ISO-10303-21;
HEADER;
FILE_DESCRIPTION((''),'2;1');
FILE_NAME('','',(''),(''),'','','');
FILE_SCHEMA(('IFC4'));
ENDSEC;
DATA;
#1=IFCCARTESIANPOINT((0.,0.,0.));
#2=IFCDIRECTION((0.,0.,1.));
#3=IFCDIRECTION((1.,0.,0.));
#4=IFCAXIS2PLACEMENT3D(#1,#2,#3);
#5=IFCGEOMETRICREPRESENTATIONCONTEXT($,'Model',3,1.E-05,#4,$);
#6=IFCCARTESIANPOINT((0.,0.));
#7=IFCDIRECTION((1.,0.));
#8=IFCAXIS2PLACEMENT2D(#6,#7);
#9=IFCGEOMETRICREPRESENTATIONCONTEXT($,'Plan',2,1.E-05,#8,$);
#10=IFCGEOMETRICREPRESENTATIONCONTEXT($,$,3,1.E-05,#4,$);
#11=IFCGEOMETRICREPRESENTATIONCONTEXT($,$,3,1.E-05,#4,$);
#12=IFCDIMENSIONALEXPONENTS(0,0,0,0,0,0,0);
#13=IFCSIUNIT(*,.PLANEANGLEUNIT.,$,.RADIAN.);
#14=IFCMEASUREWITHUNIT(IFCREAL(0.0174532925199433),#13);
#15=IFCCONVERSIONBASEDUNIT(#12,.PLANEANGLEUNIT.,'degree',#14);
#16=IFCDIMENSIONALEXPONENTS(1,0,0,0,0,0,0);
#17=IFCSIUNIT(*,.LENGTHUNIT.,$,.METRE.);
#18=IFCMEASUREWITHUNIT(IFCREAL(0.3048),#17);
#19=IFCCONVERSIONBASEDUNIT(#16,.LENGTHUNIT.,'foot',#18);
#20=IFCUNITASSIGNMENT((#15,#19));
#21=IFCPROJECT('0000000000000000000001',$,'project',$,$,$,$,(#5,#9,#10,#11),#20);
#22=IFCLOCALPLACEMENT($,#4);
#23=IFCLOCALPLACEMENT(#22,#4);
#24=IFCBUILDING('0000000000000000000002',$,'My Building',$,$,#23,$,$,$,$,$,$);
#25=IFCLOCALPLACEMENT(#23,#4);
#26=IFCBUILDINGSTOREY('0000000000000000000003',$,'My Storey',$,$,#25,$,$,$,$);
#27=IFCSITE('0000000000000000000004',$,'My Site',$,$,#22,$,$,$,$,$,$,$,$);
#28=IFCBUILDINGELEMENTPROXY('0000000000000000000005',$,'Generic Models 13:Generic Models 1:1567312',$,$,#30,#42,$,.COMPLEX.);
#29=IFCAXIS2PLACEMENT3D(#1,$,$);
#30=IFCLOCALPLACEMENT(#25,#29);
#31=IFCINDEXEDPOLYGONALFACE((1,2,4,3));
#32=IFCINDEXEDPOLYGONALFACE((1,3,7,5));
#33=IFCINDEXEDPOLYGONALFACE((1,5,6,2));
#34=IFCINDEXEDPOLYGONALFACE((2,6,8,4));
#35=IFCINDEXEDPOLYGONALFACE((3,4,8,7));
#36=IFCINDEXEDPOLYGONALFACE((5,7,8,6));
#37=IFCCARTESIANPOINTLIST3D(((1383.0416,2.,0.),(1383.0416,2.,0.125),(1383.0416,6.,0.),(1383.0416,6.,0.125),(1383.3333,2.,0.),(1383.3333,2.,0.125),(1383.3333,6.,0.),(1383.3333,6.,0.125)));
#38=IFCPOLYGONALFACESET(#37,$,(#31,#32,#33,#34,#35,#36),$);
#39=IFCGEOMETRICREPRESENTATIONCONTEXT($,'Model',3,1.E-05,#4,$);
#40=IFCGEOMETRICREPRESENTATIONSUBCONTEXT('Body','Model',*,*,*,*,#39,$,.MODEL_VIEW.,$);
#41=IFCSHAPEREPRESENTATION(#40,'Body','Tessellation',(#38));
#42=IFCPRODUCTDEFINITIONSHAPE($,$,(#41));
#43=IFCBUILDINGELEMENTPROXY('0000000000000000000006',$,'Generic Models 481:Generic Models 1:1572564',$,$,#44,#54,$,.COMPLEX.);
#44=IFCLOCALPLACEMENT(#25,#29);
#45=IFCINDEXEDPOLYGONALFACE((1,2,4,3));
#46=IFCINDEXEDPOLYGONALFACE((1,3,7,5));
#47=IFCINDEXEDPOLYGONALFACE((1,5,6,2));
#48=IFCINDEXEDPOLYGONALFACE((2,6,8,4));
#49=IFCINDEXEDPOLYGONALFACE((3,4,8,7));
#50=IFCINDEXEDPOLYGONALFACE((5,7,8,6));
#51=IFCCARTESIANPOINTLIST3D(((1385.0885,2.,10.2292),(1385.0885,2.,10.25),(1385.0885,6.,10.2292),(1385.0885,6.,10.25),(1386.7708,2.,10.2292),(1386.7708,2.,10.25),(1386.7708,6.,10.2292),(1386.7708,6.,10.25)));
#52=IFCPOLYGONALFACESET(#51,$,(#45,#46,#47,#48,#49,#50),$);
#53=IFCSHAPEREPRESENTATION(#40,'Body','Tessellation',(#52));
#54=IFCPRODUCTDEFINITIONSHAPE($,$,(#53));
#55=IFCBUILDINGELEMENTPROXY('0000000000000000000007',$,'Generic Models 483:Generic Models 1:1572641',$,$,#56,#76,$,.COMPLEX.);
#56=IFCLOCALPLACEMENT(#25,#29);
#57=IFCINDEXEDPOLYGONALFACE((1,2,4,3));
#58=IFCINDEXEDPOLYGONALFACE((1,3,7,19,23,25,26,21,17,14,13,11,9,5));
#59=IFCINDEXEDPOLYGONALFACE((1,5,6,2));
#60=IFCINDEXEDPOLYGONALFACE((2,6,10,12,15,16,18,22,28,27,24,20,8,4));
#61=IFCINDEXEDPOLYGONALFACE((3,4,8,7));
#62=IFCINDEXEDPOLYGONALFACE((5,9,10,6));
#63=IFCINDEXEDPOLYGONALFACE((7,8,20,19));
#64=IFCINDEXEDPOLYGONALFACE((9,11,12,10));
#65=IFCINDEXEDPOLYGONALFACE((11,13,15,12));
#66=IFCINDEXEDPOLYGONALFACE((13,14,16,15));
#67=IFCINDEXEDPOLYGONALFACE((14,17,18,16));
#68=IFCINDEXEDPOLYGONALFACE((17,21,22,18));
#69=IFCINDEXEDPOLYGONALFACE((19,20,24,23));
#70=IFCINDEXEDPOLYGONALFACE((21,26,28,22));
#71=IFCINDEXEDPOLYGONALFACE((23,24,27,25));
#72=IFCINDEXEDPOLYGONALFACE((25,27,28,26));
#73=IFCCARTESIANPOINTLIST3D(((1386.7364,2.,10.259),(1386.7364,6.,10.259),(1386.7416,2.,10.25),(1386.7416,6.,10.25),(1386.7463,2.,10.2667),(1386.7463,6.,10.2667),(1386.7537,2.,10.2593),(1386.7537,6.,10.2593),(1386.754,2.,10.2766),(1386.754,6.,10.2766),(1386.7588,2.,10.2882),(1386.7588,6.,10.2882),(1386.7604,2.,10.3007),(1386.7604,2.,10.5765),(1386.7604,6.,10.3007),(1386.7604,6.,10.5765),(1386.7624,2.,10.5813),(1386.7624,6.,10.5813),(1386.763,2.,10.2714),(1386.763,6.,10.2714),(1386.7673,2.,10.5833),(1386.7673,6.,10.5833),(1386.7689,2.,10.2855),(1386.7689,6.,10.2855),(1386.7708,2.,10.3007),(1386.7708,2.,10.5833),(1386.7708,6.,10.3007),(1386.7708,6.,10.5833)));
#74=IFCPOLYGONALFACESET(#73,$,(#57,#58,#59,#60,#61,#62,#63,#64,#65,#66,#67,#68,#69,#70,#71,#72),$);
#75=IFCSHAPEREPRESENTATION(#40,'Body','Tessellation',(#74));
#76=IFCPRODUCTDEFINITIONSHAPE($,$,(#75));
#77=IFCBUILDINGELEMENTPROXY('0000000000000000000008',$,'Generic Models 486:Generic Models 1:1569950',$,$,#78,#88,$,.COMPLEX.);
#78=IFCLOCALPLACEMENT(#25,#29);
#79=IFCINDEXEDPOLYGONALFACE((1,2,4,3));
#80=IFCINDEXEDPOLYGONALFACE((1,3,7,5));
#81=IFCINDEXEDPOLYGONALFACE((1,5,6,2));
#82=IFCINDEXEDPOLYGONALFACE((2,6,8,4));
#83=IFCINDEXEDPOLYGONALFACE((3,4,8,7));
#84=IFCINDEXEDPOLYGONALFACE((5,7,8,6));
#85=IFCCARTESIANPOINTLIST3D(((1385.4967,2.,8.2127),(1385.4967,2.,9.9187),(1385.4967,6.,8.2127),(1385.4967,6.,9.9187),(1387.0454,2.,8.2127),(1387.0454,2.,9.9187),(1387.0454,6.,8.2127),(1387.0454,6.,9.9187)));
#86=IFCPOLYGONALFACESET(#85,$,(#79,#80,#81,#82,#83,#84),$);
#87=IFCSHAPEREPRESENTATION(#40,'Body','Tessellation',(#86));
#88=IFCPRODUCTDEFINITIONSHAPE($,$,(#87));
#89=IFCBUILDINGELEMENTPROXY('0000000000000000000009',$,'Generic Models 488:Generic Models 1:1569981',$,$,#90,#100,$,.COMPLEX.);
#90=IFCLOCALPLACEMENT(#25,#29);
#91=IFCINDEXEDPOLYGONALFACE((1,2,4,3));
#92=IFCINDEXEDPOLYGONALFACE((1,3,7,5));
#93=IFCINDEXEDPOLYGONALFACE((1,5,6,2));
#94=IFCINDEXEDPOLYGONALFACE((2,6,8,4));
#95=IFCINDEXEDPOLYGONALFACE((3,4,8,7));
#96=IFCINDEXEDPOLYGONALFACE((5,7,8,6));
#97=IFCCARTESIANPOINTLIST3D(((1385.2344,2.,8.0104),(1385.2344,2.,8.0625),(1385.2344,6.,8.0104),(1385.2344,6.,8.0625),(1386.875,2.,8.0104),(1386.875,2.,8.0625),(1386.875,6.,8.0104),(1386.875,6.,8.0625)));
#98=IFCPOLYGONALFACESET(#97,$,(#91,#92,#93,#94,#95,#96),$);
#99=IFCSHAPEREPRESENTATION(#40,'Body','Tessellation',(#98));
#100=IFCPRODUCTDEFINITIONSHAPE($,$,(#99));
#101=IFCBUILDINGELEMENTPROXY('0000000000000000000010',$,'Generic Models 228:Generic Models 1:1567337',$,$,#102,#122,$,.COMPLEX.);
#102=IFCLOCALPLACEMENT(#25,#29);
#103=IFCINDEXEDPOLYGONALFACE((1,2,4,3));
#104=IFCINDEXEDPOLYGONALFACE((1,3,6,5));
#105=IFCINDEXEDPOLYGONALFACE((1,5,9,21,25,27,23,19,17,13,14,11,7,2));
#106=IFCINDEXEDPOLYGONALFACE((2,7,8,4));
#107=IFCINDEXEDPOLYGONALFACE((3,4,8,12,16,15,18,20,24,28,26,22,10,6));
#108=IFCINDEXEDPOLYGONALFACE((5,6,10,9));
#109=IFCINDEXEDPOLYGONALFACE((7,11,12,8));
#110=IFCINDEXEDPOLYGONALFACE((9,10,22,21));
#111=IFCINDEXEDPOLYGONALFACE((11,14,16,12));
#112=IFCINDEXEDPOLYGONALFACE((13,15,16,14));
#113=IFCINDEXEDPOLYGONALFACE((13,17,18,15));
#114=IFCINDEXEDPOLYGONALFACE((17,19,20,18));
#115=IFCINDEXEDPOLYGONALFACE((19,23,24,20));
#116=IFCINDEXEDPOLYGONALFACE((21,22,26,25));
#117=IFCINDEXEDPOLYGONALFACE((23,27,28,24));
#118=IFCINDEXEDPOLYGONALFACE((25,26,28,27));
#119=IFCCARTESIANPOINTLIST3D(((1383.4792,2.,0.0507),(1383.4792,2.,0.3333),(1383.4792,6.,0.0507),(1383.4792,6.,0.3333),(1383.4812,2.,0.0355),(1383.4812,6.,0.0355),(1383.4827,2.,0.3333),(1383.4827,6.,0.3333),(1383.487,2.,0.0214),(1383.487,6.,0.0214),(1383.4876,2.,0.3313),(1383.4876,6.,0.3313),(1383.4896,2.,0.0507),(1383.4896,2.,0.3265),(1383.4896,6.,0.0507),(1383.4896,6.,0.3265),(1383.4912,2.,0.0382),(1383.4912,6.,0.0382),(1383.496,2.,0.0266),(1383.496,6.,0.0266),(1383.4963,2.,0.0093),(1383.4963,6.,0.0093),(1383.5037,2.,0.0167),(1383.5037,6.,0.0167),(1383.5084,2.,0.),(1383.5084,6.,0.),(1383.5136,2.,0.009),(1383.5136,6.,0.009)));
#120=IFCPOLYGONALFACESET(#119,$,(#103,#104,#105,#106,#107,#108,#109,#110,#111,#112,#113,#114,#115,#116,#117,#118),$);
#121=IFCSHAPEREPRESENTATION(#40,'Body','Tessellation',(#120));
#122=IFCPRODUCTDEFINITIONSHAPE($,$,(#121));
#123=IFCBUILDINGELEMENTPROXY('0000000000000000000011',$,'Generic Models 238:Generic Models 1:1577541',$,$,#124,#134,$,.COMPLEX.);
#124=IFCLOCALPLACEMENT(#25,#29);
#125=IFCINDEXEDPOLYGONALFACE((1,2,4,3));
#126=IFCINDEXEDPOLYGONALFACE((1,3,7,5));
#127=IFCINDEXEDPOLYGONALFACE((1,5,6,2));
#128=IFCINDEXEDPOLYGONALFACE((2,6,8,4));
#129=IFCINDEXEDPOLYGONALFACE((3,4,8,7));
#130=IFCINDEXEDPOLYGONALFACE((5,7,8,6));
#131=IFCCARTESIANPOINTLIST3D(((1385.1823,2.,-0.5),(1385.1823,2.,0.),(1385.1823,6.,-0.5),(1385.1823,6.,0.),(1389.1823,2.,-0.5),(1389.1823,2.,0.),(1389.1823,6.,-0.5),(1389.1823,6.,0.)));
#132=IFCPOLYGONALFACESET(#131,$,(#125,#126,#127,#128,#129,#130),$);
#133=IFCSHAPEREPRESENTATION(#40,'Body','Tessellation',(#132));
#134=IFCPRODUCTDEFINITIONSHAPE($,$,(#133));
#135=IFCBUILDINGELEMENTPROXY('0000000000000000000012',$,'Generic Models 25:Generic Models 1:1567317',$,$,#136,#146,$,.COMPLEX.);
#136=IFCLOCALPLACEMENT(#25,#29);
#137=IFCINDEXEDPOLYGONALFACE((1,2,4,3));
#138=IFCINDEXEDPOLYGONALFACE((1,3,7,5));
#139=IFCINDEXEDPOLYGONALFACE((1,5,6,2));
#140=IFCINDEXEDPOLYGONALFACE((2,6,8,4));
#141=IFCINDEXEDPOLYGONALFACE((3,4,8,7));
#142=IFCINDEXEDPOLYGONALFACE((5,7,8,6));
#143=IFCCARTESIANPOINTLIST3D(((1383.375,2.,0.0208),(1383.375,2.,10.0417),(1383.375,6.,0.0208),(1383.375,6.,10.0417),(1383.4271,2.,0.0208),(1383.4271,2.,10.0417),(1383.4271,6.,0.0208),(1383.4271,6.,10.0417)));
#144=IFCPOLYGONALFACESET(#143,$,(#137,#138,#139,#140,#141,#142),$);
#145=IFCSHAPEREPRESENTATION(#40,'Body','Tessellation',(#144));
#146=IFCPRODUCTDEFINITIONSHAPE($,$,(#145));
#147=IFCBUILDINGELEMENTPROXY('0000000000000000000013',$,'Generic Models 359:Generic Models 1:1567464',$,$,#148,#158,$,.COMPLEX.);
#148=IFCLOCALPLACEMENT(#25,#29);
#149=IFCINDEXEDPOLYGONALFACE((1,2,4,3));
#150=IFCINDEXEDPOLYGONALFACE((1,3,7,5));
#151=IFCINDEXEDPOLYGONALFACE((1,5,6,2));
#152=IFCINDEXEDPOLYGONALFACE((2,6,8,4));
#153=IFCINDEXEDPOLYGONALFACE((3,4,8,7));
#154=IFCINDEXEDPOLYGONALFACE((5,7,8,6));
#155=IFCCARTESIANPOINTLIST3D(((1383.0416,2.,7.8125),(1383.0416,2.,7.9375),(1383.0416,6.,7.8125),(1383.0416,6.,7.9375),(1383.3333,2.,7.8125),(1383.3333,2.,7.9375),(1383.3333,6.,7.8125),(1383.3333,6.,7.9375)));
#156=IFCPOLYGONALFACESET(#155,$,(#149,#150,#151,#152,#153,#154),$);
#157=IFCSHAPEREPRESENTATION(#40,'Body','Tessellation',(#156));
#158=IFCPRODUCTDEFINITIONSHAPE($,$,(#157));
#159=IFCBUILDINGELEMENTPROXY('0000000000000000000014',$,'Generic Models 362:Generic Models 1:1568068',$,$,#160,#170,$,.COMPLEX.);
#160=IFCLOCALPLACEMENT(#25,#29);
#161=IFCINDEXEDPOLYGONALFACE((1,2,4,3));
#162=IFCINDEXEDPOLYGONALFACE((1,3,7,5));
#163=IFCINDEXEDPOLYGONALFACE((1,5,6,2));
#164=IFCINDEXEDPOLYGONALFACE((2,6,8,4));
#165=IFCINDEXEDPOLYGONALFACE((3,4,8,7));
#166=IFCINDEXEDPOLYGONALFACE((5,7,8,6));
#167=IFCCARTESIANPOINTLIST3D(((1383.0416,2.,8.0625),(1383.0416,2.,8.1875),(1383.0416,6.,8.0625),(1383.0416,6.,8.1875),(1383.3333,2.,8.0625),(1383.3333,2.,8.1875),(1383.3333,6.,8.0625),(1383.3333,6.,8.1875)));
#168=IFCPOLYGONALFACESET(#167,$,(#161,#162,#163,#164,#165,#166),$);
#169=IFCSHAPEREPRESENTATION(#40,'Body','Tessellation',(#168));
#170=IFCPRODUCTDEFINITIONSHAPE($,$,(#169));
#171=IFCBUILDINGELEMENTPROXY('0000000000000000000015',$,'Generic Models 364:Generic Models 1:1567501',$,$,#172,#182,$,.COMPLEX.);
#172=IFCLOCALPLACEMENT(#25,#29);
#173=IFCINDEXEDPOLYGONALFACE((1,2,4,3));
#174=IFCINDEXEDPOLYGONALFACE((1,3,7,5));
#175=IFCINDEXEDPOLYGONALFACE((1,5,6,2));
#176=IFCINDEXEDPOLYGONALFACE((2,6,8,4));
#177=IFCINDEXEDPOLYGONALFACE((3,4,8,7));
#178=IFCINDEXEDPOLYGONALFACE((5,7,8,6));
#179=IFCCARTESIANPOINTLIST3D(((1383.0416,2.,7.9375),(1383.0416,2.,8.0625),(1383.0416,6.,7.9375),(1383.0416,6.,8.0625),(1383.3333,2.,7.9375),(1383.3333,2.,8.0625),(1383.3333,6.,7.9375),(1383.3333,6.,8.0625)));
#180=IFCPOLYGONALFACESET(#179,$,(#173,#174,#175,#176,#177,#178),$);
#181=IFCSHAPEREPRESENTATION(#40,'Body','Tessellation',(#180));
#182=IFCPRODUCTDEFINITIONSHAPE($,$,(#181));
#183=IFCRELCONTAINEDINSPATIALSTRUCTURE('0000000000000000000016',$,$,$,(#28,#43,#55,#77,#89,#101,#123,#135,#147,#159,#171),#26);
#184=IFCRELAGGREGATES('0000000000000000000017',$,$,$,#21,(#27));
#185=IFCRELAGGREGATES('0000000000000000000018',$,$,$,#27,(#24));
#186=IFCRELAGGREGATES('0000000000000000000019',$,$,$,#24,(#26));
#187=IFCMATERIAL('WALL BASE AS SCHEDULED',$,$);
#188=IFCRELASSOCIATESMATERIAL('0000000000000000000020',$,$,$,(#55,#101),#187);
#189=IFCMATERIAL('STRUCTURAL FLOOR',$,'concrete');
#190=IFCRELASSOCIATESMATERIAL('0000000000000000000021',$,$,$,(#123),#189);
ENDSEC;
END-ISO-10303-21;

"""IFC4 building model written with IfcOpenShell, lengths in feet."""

from ifc_helpers import new_model, entity, si_unit, converted_unit, frame, origin_with_axes, origin_2d_with_axis, place, context, subcontext, project, spatial, polyline, outline, extrude, material, element, save


model = new_model("IFC4")

# Units and contexts
model_context_1 = context("Model", 3, precision=1e-05, world=origin_with_axes())
plan_context = context("Plan", 2, precision=1e-05, world=origin_2d_with_axis())
model_context_2 = context("Model", 3, precision=1e-05, world=origin_with_axes())
context_of_model_1 = context(None, 3, precision=1e-05, world=origin_with_axes())
context_of_model_2 = context(None, 3, precision=1e-05, world=origin_with_axes())
body_context = subcontext(model_context_2, "Body", "Model", "MODEL_VIEW")
ifc_project = project(units=[converted_unit("PLANEANGLEUNIT", "degree", entity("IfcReal", 0.0174532925199433), si_unit("PLANEANGLEUNIT", "RADIAN"), dimensions=[0, 0, 0, 0, 0, 0, 0]), converted_unit("LENGTHUNIT", "foot", entity("IfcReal", 0.3048), si_unit("LENGTHUNIT", "METRE"), dimensions=[1, 0, 0, 0, 0, 0, 0])], contexts=[model_context_1, plan_context, context_of_model_1, context_of_model_2])

# Site, building, storey
site_placement = place(None, origin_with_axes())
site = spatial("IfcSite", under=ifc_project, at=site_placement, Name="My Site")
building_placement = place(site_placement, origin_with_axes())
building = spatial("IfcBuilding", under=site, at=building_placement, Name="My Building")
storey_placement = place(building_placement, origin_with_axes())
storey = spatial("IfcBuildingStorey", under=building, at=storey_placement, Name="My Storey")

# Building element proxies
proxy_1_placement = place(storey_placement, frame((1383.0416, 6.0, 0.0), z_axis=(0.0, -1.0, 0.0), x_axis=(0.0, 0.0, 1.0)))
element("IfcBuildingElementProxy", 1, at=proxy_1_placement, inside=storey, Name="Generic Models 13:Generic Models 1:1567312", PredefinedType="COMPLEX", context=body_context, shape_type="SweptSolid", body=[
    extrude(outline(polyline([(-0.0625, -0.1458), (0.0625, -0.1458), (0.0625, 0.1458), (-0.0625, 0.1458), (-0.0625, -0.1458)])), frame((0.0625, -0.1458, 0.0), z_axis=(0.0, 0.0, -1.0), x_axis=(1.0, 0.0, 0.0)), (0.0, 0.0, -1.0), 4.0),
])
proxy_2_placement = place(storey_placement, frame((1385.0885, 6.0, 10.2292), z_axis=(0.0, -1.0, 0.0), x_axis=(0.0, 0.0, 1.0)))
element("IfcBuildingElementProxy", 2, at=proxy_2_placement, inside=storey, Name="Generic Models 481:Generic Models 1:1572564", PredefinedType="COMPLEX", context=body_context, shape_type="SweptSolid", body=[
    extrude(outline(polyline([(0.8412, 0.0), (0.841, 0.0208), (-0.8412, 0.0), (-0.841, -0.0208), (0.8412, 0.0)])), frame((0.0104, -0.8411, 0.0), z_axis=(0.0, 0.0, -1.0), x_axis=(0.012383, -0.999923, 0.0)), (0.0, 0.0, -1.0), 4.0),
])
ifc_material_1 = material(Name="WALL BASE AS SCHEDULED")
proxy_3_placement = place(storey_placement, frame((1386.7364, 6.0, 10.25), z_axis=(0.0, -1.0, 0.0), x_axis=(0.0, 0.0, 1.0)))
element("IfcBuildingElementProxy", 3, at=proxy_3_placement, inside=storey, material=ifc_material_1, Name="Generic Models 483:Generic Models 1:1572641", PredefinedType="COMPLEX", context=body_context, shape_type="SweptSolid", body=[
    extrude(outline(polyline([(0.2205, 0.0), (0.2206, 0.0036), (-0.0618, 0.0152), (-0.077, 0.0138), (-0.0914, 0.0086), (-0.1038, -0.0002), (-0.1136, -0.012), (-0.1048, -0.0175), (-0.0968, -0.0079), (-0.0865, -0.0007), (-0.0747, 0.0037), (-0.0622, 0.0048), (0.2133, -0.0066), (0.2183, -0.0048), (0.2205, 0.0)])), frame((0.113, -0.0218, 0.0), z_axis=(0.0, 0.0, -1.0), x_axis=(0.999153, -0.041137, 0.0)), (0.0, 0.0, -1.0), 4.0),
])
proxy_4_placement = place(storey_placement, frame((1385.4967, 6.0, 8.2127), z_axis=(0.0, -1.0, 0.0), x_axis=(0.0, 0.0, 1.0)))
element("IfcBuildingElementProxy", 4, at=proxy_4_placement, inside=storey, Name="Generic Models 486:Generic Models 1:1569950", PredefinedType="COMPLEX", context=body_context, shape_type="SweptSolid", body=[
    extrude(outline(polyline([(-0.853, -0.7743), (0.853, -0.7743), (0.853, 0.7743), (-0.853, 0.7743), (-0.853, -0.7743)])), frame((0.853, -0.7743, 0.0), z_axis=(0.0, 0.0, -1.0), x_axis=(-1.0, 0.0, 0.0)), (0.0, 0.0, -1.0), 4.0),
])
proxy_5_placement = place(storey_placement, frame((1385.2344, 6.0, 8.0104), z_axis=(0.0, -1.0, 0.0), x_axis=(0.0, 0.0, 1.0)))
element("IfcBuildingElementProxy", 5, at=proxy_5_placement, inside=storey, Name="Generic Models 488:Generic Models 1:1569981", PredefinedType="COMPLEX", context=body_context, shape_type="SweptSolid", body=[
    extrude(outline(polyline([(-0.026, -0.8203), (0.026, -0.8203), (0.026, 0.8203), (-0.026, 0.8203), (-0.026, -0.8203)])), frame((0.026, -0.8203, 0.0), z_axis=(0.0, 0.0, -1.0), x_axis=(1.0, 0.0, 0.0)), (0.0, 0.0, -1.0), 4.0),
])
proxy_6_placement = place(storey_placement, frame((1383.4792, 6.0, 0.0), z_axis=(0.0, -1.0, 0.0), x_axis=(0.0, 0.0, 1.0)))
element("IfcBuildingElementProxy", 6, at=proxy_6_placement, inside=storey, material=ifc_material_1, Name="Generic Models 228:Generic Models 1:1567337", PredefinedType="COMPLEX", context=body_context, shape_type="SweptSolid", body=[
    extrude(outline(polyline([(0.2206, 0.0), (0.2204, 0.0036), (0.2182, 0.0083), (0.2132, 0.01), (-0.0621, -0.0058), (-0.0747, -0.0049), (-0.0865, -0.0007), (-0.0969, 0.0063), (-0.1051, 0.0158), (-0.1138, 0.0101), (-0.1038, -0.0014), (-0.0912, -0.01), (-0.0768, -0.0151), (-0.0615, -0.0162), (0.2206, 0.0)])), frame((0.113, -0.0126, 0.0), z_axis=(0.0, 0.0, -1.0), x_axis=(0.998358, 0.057286, 0.0)), (0.0, 0.0, -1.0), 4.0),
])
ifc_material_2 = material(Name="STRUCTURAL FLOOR", Category="concrete")
proxy_7_placement = place(storey_placement, frame((1385.1823, 6.0, -0.5), z_axis=(0.0, -1.0, 0.0), x_axis=(0.0, 0.0, 1.0)))
element("IfcBuildingElementProxy", 7, at=proxy_7_placement, inside=storey, material=ifc_material_2, Name="Generic Models 238:Generic Models 1:1577541", PredefinedType="COMPLEX", context=body_context, shape_type="SweptSolid", body=[
    extrude(outline(polyline([(-0.25, -2.0), (0.25, -2.0), (0.25, 2.0), (-0.25, 2.0), (-0.25, -2.0)])), frame((0.25, -2.0, 0.0), z_axis=(0.0, 0.0, -1.0), x_axis=(1.0, 0.0, 0.0)), (0.0, 0.0, -1.0), 4.0),
])
proxy_8_placement = place(storey_placement, frame((1383.375, 6.0, 0.0208), z_axis=(0.0, -1.0, 0.0), x_axis=(0.0, 0.0, 1.0)))
element("IfcBuildingElementProxy", 8, at=proxy_8_placement, inside=storey, Name="Generic Models 25:Generic Models 1:1567317", PredefinedType="COMPLEX", context=body_context, shape_type="SweptSolid", body=[
    extrude(outline(polyline([(-5.0104, -0.026), (5.0104, -0.026), (5.0104, 0.026), (-5.0104, 0.026), (-5.0104, -0.026)])), frame((5.0104, -0.026, 0.0), z_axis=(0.0, 0.0, -1.0), x_axis=(1.0, 0.0, 0.0)), (0.0, 0.0, -1.0), 4.0),
])
proxy_9_placement = place(storey_placement, frame((1383.0416, 6.0, 7.8125), z_axis=(0.0, -1.0, 0.0), x_axis=(0.0, 0.0, 1.0)))
element("IfcBuildingElementProxy", 9, at=proxy_9_placement, inside=storey, Name="Generic Models 359:Generic Models 1:1567464", PredefinedType="COMPLEX", context=body_context, shape_type="SweptSolid", body=[
    extrude(outline(polyline([(-0.1458, -0.0625), (0.1458, -0.0625), (0.1458, 0.0625), (-0.1458, 0.0625), (-0.1458, -0.0625)])), frame((0.0625, -0.1458, 0.0), z_axis=(0.0, 0.0, -1.0), x_axis=(0.0, 1.0, 0.0)), (0.0, 0.0, -1.0), 4.0),
])
proxy_10_placement = place(storey_placement, frame((1383.0416, 6.0, 8.0625), z_axis=(0.0, -1.0, 0.0), x_axis=(0.0, 0.0, 1.0)))
element("IfcBuildingElementProxy", 10, at=proxy_10_placement, inside=storey, Name="Generic Models 362:Generic Models 1:1568068", PredefinedType="COMPLEX", context=body_context, shape_type="SweptSolid", body=[
    extrude(outline(polyline([(-0.0625, -0.1458), (0.0625, -0.1458), (0.0625, 0.1458), (-0.0625, 0.1458), (-0.0625, -0.1458)])), frame((0.0625, -0.1458, 0.0), z_axis=(0.0, 0.0, -1.0), x_axis=(-1.0, 0.0, 0.0)), (0.0, 0.0, -1.0), 4.0),
])
proxy_11_placement = place(storey_placement, frame((1383.0416, 6.0, 7.9375), z_axis=(0.0, -1.0, 0.0), x_axis=(0.0, 0.0, 1.0)))
element("IfcBuildingElementProxy", 11, at=proxy_11_placement, inside=storey, Name="Generic Models 364:Generic Models 1:1567501", PredefinedType="COMPLEX", context=body_context, shape_type="SweptSolid", body=[
    extrude(outline(polyline([(-0.1458, -0.0625), (0.1458, -0.0625), (0.1458, 0.0625), (-0.1458, 0.0625), (-0.1458, -0.0625)])), frame((0.0625, -0.1458, 0.0), z_axis=(0.0, 0.0, -1.0), x_axis=(0.0, 1.0, 0.0)), (0.0, 0.0, -1.0), 4.0),
])

save(model, "model.ifc")
